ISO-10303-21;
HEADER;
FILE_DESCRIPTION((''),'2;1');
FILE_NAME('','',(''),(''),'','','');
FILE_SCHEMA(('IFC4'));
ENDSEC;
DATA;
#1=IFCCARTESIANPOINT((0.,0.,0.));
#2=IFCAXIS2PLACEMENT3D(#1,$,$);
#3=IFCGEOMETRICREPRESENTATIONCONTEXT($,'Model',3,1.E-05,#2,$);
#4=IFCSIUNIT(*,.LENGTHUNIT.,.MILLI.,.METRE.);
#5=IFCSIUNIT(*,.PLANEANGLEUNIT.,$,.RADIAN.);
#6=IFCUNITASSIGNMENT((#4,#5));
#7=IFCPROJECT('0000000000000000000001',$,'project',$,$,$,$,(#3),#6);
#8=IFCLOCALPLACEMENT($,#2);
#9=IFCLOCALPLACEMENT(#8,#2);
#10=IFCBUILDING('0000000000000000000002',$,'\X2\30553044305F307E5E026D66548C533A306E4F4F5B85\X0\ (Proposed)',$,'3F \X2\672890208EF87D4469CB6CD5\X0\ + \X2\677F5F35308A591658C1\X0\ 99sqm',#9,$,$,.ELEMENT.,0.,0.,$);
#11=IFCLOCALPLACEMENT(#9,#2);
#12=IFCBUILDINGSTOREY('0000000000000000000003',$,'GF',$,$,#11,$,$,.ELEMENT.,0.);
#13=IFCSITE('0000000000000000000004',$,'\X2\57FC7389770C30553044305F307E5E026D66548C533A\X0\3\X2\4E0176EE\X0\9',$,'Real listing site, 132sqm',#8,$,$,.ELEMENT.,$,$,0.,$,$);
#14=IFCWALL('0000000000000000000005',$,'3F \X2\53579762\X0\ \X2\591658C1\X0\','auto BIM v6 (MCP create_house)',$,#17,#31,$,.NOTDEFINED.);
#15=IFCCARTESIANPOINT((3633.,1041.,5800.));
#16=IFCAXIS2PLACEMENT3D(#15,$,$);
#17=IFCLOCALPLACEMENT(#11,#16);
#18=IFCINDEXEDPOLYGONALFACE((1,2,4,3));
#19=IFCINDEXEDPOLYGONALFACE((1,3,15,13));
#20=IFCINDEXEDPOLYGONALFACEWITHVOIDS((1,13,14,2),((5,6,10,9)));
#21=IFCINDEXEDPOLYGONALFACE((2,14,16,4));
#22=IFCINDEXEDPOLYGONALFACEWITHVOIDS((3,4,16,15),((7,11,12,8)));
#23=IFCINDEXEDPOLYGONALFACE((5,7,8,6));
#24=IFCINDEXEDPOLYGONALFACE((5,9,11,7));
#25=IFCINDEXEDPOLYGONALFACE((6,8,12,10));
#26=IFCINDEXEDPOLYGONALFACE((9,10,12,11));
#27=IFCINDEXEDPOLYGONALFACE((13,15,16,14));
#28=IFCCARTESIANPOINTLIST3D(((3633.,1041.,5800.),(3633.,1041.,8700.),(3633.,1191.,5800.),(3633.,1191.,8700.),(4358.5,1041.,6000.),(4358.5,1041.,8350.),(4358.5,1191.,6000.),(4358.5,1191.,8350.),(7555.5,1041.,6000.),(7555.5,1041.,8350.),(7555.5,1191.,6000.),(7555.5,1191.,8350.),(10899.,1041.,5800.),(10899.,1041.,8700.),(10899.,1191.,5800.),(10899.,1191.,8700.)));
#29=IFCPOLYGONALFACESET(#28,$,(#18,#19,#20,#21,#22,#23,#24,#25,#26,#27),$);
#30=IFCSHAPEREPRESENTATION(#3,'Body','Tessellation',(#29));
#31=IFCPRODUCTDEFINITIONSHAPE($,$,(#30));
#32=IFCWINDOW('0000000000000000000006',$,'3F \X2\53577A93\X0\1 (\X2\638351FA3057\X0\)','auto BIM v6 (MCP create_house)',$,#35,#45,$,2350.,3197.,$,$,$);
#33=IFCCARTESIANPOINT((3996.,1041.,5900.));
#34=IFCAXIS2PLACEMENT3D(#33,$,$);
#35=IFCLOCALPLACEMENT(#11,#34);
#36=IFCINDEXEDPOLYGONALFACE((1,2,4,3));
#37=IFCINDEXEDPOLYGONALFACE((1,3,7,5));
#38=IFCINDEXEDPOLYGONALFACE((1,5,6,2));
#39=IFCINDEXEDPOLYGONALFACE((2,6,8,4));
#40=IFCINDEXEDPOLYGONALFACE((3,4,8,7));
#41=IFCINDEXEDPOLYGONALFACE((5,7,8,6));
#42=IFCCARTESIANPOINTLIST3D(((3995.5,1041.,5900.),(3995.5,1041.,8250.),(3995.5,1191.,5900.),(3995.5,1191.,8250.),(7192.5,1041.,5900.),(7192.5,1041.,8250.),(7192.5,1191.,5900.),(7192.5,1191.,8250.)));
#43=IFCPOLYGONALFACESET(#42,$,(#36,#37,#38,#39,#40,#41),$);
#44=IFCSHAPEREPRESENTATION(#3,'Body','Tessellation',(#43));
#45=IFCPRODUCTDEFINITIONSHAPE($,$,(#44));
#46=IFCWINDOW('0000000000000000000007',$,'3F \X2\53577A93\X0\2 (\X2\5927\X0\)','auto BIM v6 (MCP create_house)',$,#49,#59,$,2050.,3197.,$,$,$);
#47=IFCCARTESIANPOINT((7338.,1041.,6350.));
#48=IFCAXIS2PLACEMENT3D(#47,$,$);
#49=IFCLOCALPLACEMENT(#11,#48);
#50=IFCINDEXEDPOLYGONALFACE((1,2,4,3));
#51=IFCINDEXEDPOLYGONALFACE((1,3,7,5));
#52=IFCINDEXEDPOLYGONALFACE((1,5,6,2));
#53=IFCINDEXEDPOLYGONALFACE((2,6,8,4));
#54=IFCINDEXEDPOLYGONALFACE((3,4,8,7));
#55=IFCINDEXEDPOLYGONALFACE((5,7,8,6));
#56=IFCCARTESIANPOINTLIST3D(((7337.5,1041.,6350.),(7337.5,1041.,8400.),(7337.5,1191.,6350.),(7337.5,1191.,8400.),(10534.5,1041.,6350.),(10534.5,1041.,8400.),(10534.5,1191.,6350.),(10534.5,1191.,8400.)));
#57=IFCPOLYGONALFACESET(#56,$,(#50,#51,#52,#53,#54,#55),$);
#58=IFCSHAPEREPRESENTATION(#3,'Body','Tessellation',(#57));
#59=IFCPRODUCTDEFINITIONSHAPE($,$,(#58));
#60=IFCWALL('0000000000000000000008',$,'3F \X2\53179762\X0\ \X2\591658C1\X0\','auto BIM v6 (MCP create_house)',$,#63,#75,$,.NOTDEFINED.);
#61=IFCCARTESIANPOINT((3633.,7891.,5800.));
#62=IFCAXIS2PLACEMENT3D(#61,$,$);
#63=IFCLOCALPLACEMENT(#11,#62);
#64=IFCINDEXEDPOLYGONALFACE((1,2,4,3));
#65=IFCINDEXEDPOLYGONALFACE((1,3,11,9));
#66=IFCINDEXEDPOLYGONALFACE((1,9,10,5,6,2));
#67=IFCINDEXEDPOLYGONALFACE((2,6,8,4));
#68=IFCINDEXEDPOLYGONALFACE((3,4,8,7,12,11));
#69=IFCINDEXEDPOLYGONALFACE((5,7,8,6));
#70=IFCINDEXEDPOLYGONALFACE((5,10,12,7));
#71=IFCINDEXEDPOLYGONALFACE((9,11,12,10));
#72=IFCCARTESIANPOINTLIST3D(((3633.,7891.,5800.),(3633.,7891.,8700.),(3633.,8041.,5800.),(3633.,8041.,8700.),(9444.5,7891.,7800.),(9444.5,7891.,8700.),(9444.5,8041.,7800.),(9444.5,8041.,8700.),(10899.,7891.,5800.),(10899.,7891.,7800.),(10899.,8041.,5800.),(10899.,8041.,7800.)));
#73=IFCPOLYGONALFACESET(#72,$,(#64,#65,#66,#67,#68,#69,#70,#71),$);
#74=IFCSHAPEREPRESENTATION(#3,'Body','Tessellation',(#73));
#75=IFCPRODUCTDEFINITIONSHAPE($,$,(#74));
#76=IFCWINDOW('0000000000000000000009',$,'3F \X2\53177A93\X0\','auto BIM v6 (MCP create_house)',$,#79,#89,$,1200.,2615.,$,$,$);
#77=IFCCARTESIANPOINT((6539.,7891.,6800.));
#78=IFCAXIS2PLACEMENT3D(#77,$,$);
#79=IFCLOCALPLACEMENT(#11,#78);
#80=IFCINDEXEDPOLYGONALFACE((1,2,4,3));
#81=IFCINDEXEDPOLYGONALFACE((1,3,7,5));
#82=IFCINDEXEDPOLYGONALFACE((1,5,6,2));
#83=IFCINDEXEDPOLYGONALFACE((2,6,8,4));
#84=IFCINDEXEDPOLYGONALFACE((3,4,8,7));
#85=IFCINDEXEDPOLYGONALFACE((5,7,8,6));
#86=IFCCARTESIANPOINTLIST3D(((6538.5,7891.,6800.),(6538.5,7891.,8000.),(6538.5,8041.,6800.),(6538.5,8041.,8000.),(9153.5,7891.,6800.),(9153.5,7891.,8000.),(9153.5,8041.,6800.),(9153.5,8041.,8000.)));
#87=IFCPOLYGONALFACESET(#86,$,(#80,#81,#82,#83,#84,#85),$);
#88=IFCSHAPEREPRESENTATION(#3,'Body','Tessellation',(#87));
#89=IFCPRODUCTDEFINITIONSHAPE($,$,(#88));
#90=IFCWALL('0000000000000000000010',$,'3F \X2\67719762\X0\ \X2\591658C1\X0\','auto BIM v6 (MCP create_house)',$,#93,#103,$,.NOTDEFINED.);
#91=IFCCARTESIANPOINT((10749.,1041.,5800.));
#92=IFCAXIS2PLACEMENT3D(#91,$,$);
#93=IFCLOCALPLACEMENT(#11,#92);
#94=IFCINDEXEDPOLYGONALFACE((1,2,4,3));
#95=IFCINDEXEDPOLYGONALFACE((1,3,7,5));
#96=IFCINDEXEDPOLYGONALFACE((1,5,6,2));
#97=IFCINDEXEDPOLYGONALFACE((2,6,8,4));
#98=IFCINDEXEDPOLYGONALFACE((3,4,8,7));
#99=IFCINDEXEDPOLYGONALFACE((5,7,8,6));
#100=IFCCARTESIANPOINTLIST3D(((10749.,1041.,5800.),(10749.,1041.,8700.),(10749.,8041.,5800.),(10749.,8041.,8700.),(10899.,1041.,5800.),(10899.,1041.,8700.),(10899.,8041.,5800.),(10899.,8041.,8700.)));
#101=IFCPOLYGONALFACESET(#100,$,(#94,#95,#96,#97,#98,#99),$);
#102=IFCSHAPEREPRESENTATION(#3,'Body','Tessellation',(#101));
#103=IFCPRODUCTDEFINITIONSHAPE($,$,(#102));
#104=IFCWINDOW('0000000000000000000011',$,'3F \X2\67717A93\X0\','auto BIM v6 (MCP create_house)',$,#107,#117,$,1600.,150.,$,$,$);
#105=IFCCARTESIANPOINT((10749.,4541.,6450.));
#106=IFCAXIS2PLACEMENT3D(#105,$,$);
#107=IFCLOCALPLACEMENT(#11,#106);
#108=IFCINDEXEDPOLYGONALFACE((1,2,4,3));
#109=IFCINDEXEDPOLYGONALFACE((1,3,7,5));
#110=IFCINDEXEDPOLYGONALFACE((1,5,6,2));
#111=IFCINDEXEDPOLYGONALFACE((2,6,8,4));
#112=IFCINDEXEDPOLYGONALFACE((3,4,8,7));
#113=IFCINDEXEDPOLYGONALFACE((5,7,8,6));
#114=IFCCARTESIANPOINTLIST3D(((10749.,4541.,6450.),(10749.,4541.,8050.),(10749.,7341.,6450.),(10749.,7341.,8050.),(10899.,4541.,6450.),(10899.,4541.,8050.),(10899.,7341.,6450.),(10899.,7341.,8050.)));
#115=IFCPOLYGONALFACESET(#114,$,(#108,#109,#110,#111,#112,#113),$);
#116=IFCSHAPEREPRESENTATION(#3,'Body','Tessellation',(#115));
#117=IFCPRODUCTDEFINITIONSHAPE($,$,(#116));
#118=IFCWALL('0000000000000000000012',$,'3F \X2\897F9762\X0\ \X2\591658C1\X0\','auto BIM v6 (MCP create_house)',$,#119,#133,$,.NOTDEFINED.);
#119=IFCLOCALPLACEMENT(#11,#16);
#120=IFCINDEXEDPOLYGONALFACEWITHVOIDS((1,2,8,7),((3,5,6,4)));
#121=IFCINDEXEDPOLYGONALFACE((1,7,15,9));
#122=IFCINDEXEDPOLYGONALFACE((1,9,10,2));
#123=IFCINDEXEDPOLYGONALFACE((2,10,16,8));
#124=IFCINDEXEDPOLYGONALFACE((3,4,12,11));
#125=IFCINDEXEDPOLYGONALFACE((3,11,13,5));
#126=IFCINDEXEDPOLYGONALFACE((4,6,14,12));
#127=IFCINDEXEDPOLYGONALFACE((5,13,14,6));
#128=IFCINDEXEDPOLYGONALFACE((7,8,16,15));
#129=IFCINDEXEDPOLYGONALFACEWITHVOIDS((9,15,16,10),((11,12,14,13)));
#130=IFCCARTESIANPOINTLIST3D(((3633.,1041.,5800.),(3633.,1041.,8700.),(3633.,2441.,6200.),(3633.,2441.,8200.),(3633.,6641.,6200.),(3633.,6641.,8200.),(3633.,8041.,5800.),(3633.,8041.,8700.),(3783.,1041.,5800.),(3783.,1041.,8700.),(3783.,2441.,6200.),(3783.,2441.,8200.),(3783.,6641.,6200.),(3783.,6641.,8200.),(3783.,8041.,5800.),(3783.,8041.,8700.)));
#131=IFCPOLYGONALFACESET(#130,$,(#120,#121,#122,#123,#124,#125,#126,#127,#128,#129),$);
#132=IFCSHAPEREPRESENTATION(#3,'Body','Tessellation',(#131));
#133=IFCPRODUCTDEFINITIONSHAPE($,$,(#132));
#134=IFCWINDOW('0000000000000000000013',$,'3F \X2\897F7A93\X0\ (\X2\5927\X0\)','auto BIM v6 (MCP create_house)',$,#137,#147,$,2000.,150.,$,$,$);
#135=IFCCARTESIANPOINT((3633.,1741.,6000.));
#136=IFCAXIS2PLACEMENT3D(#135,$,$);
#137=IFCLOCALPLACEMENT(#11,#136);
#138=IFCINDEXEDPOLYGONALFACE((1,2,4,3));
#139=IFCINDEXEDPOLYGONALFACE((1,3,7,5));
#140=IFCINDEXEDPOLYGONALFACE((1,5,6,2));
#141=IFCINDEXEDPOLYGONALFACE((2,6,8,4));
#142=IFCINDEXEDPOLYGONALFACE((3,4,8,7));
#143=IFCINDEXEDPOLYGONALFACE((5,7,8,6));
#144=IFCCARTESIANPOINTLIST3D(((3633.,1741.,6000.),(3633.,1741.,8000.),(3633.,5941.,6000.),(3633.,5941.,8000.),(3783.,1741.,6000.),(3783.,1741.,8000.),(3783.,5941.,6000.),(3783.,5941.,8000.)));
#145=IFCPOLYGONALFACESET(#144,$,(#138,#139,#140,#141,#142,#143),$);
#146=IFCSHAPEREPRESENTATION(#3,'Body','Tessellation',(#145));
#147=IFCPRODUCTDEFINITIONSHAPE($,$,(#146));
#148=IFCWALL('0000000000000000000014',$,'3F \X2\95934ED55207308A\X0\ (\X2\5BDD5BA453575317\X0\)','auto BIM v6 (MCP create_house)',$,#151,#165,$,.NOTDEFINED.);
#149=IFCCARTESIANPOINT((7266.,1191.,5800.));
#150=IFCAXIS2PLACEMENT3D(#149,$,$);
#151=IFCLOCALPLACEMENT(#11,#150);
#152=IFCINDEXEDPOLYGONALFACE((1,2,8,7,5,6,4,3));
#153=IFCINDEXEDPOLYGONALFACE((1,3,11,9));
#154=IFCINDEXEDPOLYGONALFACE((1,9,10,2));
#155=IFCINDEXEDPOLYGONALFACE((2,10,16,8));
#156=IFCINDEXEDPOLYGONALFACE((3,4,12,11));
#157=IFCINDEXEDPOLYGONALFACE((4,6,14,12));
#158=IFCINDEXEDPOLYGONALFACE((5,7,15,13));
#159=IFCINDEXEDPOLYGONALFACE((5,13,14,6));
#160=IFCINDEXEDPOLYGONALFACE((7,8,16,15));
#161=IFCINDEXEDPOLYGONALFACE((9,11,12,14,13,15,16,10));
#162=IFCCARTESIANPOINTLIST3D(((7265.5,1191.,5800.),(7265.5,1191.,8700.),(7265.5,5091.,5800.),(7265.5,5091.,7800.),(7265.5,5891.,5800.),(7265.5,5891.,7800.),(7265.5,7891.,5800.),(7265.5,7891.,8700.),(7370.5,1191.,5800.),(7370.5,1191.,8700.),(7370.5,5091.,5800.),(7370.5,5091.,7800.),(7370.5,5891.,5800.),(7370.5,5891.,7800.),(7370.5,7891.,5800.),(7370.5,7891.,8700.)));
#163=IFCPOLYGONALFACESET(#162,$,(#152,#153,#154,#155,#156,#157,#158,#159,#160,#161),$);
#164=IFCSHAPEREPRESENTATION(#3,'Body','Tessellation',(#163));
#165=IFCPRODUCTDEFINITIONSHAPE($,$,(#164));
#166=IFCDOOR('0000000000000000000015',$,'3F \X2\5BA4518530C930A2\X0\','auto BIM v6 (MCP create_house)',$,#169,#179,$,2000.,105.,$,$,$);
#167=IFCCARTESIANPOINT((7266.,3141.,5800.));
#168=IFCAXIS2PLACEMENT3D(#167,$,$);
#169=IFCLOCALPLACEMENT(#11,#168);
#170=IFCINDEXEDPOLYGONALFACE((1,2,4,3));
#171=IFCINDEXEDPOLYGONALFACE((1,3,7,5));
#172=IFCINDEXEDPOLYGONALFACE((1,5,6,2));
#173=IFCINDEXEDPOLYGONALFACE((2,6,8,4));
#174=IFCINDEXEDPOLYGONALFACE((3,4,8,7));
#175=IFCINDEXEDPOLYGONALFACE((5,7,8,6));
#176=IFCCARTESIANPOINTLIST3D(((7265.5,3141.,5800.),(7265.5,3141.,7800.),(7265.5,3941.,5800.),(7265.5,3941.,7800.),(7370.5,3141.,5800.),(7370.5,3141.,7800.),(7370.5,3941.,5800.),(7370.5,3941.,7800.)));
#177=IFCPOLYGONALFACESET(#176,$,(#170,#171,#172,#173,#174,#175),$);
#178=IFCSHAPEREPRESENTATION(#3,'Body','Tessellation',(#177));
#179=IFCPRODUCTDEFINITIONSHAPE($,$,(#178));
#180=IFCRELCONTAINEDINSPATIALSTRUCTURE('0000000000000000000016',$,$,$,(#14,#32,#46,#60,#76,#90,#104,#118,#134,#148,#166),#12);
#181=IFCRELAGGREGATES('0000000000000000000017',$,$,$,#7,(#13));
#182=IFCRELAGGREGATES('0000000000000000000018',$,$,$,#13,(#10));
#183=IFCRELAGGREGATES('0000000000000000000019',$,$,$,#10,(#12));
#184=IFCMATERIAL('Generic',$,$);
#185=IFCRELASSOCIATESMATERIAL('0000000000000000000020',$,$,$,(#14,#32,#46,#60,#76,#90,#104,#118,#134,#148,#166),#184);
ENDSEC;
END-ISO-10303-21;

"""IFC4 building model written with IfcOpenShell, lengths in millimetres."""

from ifc_helpers import new_model, si_unit, frame, frame_2d, origin, place, context, project, spatial, rectangle, extrude, material, element, fill, save


model = new_model("IFC4")

# Units and contexts
model_context = context("Model", 3, precision=1e-05, world=origin())
ifc_project = project(units=[si_unit("LENGTHUNIT", "METRE", prefix="MILLI"), si_unit("PLANEANGLEUNIT", "RADIAN")], contexts=[model_context])

# Site, building, storey
site_placement = place(None, origin())
site = spatial("IfcSite", under=ifc_project, at=site_placement, Name="埼玉県さいたま市浦和区3丁目9", ObjectType="Real listing site, 132sqm", CompositionType="ELEMENT", RefElevation=0.0)
building_placement = place(site_placement, origin())
building = spatial("IfcBuilding", under=site, at=building_placement, Name="さいたま市浦和区の住宅 (Proposed)", ObjectType="3F 木造軸組構法 + 板張り外壁 99sqm", CompositionType="ELEMENT", ElevationOfRefHeight=0.0, ElevationOfTerrain=0.0)
storey_placement = place(building_placement, origin())
storey = spatial("IfcBuildingStorey", under=building, at=storey_placement, Name="GF", CompositionType="ELEMENT", Elevation=0.0)

# Shared definitions
ifc_material = material(Name="Generic")

# Wall, openings, windows
wall_1_placement = place(storey_placement, frame((3633.0, 1041.0, 5800.0)))
wall_1 = element("IfcWall", 1, at=wall_1_placement, inside=storey, material=ifc_material, Name="3F 南面 外壁", Description="auto BIM v6 (MCP create_house)", PredefinedType="NOTDEFINED", context=model_context, shape_type="SweptSolid", body=[
    extrude(rectangle(XDim=7266.0, YDim=150.0, at=frame_2d((3633.0, 75.0))), frame((3633.0, 1041.0, 5800.0)), (0.0, 0.0, 1.0), 2900.0),
])
opening_1_placement = place(storey_placement, frame((3996.0, 1041.0, 5900.0)))
opening_1 = element("IfcOpeningElement", 2, at=opening_1_placement, cuts=wall_1, PredefinedType="NOTDEFINED", context=model_context, shape_type="SweptSolid", body=[
    extrude(rectangle(XDim=3197.0, YDim=150.0, at=frame_2d((1598.0, 75.0))), frame((3996.0, 1041.0, 5900.0)), (0.0, 0.0, 1.0), 2350.0),
])
opening_2_placement = place(storey_placement, frame((7338.0, 1041.0, 6350.0)))
opening_2 = element("IfcOpeningElement", 3, at=opening_2_placement, cuts=wall_1, PredefinedType="NOTDEFINED", context=model_context, shape_type="SweptSolid", body=[
    extrude(rectangle(XDim=3197.0, YDim=150.0, at=frame_2d((1598.0, 75.0))), frame((7338.0, 1041.0, 6350.0)), (0.0, 0.0, 1.0), 2050.0),
])
window_1_placement = place(storey_placement, frame((3996.0, 1041.0, 5900.0)))
window_1 = element("IfcWindow", 4, at=window_1_placement, inside=storey, material=ifc_material, Name="3F 南窓1 (掃出し)", Description="auto BIM v6 (MCP create_house)", OverallHeight=2350.0, OverallWidth=3197.0, context=model_context, shape_type="SweptSolid", body=[
    extrude(rectangle(XDim=3197.0, YDim=150.0, at=frame_2d((1598.0, 75.0))), frame((3996.0, 1041.0, 5900.0)), (0.0, 0.0, 1.0), 2350.0),
])
fill(opening_1, window_1)
window_2_placement = place(storey_placement, frame((7338.0, 1041.0, 6350.0)))
window_2 = element("IfcWindow", 5, at=window_2_placement, inside=storey, material=ifc_material, Name="3F 南窓2 (大)", Description="auto BIM v6 (MCP create_house)", OverallHeight=2050.0, OverallWidth=3197.0, context=model_context, shape_type="SweptSolid", body=[
    extrude(rectangle(XDim=3197.0, YDim=150.0, at=frame_2d((1598.0, 75.0))), frame((7338.0, 1041.0, 6350.0)), (0.0, 0.0, 1.0), 2050.0),
])
fill(opening_2, window_2)

# Walls, openings, windows
wall_2_placement = place(storey_placement, frame((3633.0, 7891.0, 5800.0)))
wall_2 = element("IfcWall", 6, at=wall_2_placement, inside=storey, material=ifc_material, Name="3F 北面 外壁", Description="auto BIM v6 (MCP create_house)", PredefinedType="NOTDEFINED", context=model_context, shape_type="SweptSolid", body=[
    extrude(rectangle(XDim=7266.0, YDim=150.0, at=frame_2d((3633.0, 75.0))), frame((3633.0, 7891.0, 5800.0)), (0.0, 0.0, 1.0), 2900.0),
])
opening_3_placement = place(storey_placement, frame((6539.0, 7891.0, 6800.0)))
opening_3 = element("IfcOpeningElement", 7, at=opening_3_placement, cuts=wall_2, PredefinedType="NOTDEFINED", context=model_context, shape_type="SweptSolid", body=[
    extrude(rectangle(XDim=2615.0, YDim=150.0, at=frame_2d((1307.0, 75.0))), frame((6539.0, 7891.0, 6800.0)), (0.0, 0.0, 1.0), 1200.0),
])
window_3_placement = place(storey_placement, frame((6539.0, 7891.0, 6800.0)))
window_3 = element("IfcWindow", 8, at=window_3_placement, inside=storey, material=ifc_material, Name="3F 北窓", Description="auto BIM v6 (MCP create_house)", OverallHeight=1200.0, OverallWidth=2615.0, context=model_context, shape_type="SweptSolid", body=[
    extrude(rectangle(XDim=2615.0, YDim=150.0, at=frame_2d((1307.0, 75.0))), frame((6539.0, 7891.0, 6800.0)), (0.0, 0.0, 1.0), 1200.0),
])
fill(opening_3, window_3)
wall_3_placement = place(storey_placement, frame((10749.0, 1041.0, 5800.0)))
wall_3 = element("IfcWall", 9, at=wall_3_placement, inside=storey, material=ifc_material, Name="3F 東面 外壁", Description="auto BIM v6 (MCP create_house)", PredefinedType="NOTDEFINED", context=model_context, shape_type="SweptSolid", body=[
    extrude(rectangle(XDim=150.0, YDim=7000.0, at=frame_2d((75.0, 3500.0))), frame((10749.0, 1041.0, 5800.0)), (0.0, 0.0, 1.0), 2900.0),
])
opening_4_placement = place(storey_placement, frame((10749.0, 4541.0, 6450.0)))
opening_4 = element("IfcOpeningElement", 10, at=opening_4_placement, cuts=wall_3, PredefinedType="NOTDEFINED", context=model_context, shape_type="SweptSolid", body=[
    extrude(rectangle(XDim=150.0, YDim=2800.0, at=frame_2d((75.0, 1400.0))), frame((10749.0, 4541.0, 6450.0)), (0.0, 0.0, 1.0), 1600.0),
])
window_4_placement = place(storey_placement, frame((10749.0, 4541.0, 6450.0)))
window_4 = element("IfcWindow", 11, at=window_4_placement, inside=storey, material=ifc_material, Name="3F 東窓", Description="auto BIM v6 (MCP create_house)", OverallHeight=1600.0, OverallWidth=150.0, context=model_context, shape_type="SweptSolid", body=[
    extrude(rectangle(XDim=150.0, YDim=2800.0, at=frame_2d((75.0, 1400.0))), frame((10749.0, 4541.0, 6450.0)), (0.0, 0.0, 1.0), 1600.0),
])
fill(opening_4, window_4)
wall_4_placement = place(storey_placement, frame((3633.0, 1041.0, 5800.0)))
wall_4 = element("IfcWall", 12, at=wall_4_placement, inside=storey, material=ifc_material, Name="3F 西面 外壁", Description="auto BIM v6 (MCP create_house)", PredefinedType="NOTDEFINED", context=model_context, shape_type="SweptSolid", body=[
    extrude(rectangle(XDim=150.0, YDim=7000.0, at=frame_2d((75.0, 3500.0))), frame((3633.0, 1041.0, 5800.0)), (0.0, 0.0, 1.0), 2900.0),
])
opening_5_placement = place(storey_placement, frame((3633.0, 1741.0, 6000.0)))
opening_5 = element("IfcOpeningElement", 13, at=opening_5_placement, cuts=wall_4, PredefinedType="NOTDEFINED", context=model_context, shape_type="SweptSolid", body=[
    extrude(rectangle(XDim=150.0, YDim=4200.0, at=frame_2d((75.0, 2100.0))), frame((3633.0, 1741.0, 6000.0)), (0.0, 0.0, 1.0), 2000.0),
])
window_5_placement = place(storey_placement, frame((3633.0, 1741.0, 6000.0)))
window_5 = element("IfcWindow", 14, at=window_5_placement, inside=storey, material=ifc_material, Name="3F 西窓 (大)", Description="auto BIM v6 (MCP create_house)", OverallHeight=2000.0, OverallWidth=150.0, context=model_context, shape_type="SweptSolid", body=[
    extrude(rectangle(XDim=150.0, YDim=4200.0, at=frame_2d((75.0, 2100.0))), frame((3633.0, 1741.0, 6000.0)), (0.0, 0.0, 1.0), 2000.0),
])
fill(opening_5, window_5)

# Wall, opening, door
wall_5_placement = place(storey_placement, frame((7266.0, 1191.0, 5800.0)))
wall_5 = element("IfcWall", 15, at=wall_5_placement, inside=storey, material=ifc_material, Name="3F 間仕切り (寝室南北)", Description="auto BIM v6 (MCP create_house)", PredefinedType="NOTDEFINED", context=model_context, shape_type="SweptSolid", body=[
    extrude(rectangle(XDim=105.0, YDim=6700.0, at=frame_2d((52.0, 3350.0))), frame((7266.0, 1191.0, 5800.0)), (0.0, 0.0, 1.0), 2900.0),
])
opening_6_placement = place(storey_placement, frame((7266.0, 3141.0, 5800.0)))
opening_6 = element("IfcOpeningElement", 16, at=opening_6_placement, cuts=wall_5, PredefinedType="NOTDEFINED", context=model_context, shape_type="SweptSolid", body=[
    extrude(rectangle(XDim=105.0, YDim=800.0, at=frame_2d((52.0, 400.0))), frame((7266.0, 3141.0, 5800.0)), (0.0, 0.0, 1.0), 2000.0),
])
door_1_placement = place(storey_placement, frame((7266.0, 3141.0, 5800.0)))
door_1 = element("IfcDoor", 17, at=door_1_placement, inside=storey, material=ifc_material, Name="3F 室内ドア", Description="auto BIM v6 (MCP create_house)", OverallHeight=2000.0, OverallWidth=105.0, context=model_context, shape_type="SweptSolid", body=[
    extrude(rectangle(XDim=105.0, YDim=800.0, at=frame_2d((52.0, 400.0))), frame((7266.0, 3141.0, 5800.0)), (0.0, 0.0, 1.0), 2000.0),
])
fill(opening_6, door_1)

save(model, "model.ifc")
